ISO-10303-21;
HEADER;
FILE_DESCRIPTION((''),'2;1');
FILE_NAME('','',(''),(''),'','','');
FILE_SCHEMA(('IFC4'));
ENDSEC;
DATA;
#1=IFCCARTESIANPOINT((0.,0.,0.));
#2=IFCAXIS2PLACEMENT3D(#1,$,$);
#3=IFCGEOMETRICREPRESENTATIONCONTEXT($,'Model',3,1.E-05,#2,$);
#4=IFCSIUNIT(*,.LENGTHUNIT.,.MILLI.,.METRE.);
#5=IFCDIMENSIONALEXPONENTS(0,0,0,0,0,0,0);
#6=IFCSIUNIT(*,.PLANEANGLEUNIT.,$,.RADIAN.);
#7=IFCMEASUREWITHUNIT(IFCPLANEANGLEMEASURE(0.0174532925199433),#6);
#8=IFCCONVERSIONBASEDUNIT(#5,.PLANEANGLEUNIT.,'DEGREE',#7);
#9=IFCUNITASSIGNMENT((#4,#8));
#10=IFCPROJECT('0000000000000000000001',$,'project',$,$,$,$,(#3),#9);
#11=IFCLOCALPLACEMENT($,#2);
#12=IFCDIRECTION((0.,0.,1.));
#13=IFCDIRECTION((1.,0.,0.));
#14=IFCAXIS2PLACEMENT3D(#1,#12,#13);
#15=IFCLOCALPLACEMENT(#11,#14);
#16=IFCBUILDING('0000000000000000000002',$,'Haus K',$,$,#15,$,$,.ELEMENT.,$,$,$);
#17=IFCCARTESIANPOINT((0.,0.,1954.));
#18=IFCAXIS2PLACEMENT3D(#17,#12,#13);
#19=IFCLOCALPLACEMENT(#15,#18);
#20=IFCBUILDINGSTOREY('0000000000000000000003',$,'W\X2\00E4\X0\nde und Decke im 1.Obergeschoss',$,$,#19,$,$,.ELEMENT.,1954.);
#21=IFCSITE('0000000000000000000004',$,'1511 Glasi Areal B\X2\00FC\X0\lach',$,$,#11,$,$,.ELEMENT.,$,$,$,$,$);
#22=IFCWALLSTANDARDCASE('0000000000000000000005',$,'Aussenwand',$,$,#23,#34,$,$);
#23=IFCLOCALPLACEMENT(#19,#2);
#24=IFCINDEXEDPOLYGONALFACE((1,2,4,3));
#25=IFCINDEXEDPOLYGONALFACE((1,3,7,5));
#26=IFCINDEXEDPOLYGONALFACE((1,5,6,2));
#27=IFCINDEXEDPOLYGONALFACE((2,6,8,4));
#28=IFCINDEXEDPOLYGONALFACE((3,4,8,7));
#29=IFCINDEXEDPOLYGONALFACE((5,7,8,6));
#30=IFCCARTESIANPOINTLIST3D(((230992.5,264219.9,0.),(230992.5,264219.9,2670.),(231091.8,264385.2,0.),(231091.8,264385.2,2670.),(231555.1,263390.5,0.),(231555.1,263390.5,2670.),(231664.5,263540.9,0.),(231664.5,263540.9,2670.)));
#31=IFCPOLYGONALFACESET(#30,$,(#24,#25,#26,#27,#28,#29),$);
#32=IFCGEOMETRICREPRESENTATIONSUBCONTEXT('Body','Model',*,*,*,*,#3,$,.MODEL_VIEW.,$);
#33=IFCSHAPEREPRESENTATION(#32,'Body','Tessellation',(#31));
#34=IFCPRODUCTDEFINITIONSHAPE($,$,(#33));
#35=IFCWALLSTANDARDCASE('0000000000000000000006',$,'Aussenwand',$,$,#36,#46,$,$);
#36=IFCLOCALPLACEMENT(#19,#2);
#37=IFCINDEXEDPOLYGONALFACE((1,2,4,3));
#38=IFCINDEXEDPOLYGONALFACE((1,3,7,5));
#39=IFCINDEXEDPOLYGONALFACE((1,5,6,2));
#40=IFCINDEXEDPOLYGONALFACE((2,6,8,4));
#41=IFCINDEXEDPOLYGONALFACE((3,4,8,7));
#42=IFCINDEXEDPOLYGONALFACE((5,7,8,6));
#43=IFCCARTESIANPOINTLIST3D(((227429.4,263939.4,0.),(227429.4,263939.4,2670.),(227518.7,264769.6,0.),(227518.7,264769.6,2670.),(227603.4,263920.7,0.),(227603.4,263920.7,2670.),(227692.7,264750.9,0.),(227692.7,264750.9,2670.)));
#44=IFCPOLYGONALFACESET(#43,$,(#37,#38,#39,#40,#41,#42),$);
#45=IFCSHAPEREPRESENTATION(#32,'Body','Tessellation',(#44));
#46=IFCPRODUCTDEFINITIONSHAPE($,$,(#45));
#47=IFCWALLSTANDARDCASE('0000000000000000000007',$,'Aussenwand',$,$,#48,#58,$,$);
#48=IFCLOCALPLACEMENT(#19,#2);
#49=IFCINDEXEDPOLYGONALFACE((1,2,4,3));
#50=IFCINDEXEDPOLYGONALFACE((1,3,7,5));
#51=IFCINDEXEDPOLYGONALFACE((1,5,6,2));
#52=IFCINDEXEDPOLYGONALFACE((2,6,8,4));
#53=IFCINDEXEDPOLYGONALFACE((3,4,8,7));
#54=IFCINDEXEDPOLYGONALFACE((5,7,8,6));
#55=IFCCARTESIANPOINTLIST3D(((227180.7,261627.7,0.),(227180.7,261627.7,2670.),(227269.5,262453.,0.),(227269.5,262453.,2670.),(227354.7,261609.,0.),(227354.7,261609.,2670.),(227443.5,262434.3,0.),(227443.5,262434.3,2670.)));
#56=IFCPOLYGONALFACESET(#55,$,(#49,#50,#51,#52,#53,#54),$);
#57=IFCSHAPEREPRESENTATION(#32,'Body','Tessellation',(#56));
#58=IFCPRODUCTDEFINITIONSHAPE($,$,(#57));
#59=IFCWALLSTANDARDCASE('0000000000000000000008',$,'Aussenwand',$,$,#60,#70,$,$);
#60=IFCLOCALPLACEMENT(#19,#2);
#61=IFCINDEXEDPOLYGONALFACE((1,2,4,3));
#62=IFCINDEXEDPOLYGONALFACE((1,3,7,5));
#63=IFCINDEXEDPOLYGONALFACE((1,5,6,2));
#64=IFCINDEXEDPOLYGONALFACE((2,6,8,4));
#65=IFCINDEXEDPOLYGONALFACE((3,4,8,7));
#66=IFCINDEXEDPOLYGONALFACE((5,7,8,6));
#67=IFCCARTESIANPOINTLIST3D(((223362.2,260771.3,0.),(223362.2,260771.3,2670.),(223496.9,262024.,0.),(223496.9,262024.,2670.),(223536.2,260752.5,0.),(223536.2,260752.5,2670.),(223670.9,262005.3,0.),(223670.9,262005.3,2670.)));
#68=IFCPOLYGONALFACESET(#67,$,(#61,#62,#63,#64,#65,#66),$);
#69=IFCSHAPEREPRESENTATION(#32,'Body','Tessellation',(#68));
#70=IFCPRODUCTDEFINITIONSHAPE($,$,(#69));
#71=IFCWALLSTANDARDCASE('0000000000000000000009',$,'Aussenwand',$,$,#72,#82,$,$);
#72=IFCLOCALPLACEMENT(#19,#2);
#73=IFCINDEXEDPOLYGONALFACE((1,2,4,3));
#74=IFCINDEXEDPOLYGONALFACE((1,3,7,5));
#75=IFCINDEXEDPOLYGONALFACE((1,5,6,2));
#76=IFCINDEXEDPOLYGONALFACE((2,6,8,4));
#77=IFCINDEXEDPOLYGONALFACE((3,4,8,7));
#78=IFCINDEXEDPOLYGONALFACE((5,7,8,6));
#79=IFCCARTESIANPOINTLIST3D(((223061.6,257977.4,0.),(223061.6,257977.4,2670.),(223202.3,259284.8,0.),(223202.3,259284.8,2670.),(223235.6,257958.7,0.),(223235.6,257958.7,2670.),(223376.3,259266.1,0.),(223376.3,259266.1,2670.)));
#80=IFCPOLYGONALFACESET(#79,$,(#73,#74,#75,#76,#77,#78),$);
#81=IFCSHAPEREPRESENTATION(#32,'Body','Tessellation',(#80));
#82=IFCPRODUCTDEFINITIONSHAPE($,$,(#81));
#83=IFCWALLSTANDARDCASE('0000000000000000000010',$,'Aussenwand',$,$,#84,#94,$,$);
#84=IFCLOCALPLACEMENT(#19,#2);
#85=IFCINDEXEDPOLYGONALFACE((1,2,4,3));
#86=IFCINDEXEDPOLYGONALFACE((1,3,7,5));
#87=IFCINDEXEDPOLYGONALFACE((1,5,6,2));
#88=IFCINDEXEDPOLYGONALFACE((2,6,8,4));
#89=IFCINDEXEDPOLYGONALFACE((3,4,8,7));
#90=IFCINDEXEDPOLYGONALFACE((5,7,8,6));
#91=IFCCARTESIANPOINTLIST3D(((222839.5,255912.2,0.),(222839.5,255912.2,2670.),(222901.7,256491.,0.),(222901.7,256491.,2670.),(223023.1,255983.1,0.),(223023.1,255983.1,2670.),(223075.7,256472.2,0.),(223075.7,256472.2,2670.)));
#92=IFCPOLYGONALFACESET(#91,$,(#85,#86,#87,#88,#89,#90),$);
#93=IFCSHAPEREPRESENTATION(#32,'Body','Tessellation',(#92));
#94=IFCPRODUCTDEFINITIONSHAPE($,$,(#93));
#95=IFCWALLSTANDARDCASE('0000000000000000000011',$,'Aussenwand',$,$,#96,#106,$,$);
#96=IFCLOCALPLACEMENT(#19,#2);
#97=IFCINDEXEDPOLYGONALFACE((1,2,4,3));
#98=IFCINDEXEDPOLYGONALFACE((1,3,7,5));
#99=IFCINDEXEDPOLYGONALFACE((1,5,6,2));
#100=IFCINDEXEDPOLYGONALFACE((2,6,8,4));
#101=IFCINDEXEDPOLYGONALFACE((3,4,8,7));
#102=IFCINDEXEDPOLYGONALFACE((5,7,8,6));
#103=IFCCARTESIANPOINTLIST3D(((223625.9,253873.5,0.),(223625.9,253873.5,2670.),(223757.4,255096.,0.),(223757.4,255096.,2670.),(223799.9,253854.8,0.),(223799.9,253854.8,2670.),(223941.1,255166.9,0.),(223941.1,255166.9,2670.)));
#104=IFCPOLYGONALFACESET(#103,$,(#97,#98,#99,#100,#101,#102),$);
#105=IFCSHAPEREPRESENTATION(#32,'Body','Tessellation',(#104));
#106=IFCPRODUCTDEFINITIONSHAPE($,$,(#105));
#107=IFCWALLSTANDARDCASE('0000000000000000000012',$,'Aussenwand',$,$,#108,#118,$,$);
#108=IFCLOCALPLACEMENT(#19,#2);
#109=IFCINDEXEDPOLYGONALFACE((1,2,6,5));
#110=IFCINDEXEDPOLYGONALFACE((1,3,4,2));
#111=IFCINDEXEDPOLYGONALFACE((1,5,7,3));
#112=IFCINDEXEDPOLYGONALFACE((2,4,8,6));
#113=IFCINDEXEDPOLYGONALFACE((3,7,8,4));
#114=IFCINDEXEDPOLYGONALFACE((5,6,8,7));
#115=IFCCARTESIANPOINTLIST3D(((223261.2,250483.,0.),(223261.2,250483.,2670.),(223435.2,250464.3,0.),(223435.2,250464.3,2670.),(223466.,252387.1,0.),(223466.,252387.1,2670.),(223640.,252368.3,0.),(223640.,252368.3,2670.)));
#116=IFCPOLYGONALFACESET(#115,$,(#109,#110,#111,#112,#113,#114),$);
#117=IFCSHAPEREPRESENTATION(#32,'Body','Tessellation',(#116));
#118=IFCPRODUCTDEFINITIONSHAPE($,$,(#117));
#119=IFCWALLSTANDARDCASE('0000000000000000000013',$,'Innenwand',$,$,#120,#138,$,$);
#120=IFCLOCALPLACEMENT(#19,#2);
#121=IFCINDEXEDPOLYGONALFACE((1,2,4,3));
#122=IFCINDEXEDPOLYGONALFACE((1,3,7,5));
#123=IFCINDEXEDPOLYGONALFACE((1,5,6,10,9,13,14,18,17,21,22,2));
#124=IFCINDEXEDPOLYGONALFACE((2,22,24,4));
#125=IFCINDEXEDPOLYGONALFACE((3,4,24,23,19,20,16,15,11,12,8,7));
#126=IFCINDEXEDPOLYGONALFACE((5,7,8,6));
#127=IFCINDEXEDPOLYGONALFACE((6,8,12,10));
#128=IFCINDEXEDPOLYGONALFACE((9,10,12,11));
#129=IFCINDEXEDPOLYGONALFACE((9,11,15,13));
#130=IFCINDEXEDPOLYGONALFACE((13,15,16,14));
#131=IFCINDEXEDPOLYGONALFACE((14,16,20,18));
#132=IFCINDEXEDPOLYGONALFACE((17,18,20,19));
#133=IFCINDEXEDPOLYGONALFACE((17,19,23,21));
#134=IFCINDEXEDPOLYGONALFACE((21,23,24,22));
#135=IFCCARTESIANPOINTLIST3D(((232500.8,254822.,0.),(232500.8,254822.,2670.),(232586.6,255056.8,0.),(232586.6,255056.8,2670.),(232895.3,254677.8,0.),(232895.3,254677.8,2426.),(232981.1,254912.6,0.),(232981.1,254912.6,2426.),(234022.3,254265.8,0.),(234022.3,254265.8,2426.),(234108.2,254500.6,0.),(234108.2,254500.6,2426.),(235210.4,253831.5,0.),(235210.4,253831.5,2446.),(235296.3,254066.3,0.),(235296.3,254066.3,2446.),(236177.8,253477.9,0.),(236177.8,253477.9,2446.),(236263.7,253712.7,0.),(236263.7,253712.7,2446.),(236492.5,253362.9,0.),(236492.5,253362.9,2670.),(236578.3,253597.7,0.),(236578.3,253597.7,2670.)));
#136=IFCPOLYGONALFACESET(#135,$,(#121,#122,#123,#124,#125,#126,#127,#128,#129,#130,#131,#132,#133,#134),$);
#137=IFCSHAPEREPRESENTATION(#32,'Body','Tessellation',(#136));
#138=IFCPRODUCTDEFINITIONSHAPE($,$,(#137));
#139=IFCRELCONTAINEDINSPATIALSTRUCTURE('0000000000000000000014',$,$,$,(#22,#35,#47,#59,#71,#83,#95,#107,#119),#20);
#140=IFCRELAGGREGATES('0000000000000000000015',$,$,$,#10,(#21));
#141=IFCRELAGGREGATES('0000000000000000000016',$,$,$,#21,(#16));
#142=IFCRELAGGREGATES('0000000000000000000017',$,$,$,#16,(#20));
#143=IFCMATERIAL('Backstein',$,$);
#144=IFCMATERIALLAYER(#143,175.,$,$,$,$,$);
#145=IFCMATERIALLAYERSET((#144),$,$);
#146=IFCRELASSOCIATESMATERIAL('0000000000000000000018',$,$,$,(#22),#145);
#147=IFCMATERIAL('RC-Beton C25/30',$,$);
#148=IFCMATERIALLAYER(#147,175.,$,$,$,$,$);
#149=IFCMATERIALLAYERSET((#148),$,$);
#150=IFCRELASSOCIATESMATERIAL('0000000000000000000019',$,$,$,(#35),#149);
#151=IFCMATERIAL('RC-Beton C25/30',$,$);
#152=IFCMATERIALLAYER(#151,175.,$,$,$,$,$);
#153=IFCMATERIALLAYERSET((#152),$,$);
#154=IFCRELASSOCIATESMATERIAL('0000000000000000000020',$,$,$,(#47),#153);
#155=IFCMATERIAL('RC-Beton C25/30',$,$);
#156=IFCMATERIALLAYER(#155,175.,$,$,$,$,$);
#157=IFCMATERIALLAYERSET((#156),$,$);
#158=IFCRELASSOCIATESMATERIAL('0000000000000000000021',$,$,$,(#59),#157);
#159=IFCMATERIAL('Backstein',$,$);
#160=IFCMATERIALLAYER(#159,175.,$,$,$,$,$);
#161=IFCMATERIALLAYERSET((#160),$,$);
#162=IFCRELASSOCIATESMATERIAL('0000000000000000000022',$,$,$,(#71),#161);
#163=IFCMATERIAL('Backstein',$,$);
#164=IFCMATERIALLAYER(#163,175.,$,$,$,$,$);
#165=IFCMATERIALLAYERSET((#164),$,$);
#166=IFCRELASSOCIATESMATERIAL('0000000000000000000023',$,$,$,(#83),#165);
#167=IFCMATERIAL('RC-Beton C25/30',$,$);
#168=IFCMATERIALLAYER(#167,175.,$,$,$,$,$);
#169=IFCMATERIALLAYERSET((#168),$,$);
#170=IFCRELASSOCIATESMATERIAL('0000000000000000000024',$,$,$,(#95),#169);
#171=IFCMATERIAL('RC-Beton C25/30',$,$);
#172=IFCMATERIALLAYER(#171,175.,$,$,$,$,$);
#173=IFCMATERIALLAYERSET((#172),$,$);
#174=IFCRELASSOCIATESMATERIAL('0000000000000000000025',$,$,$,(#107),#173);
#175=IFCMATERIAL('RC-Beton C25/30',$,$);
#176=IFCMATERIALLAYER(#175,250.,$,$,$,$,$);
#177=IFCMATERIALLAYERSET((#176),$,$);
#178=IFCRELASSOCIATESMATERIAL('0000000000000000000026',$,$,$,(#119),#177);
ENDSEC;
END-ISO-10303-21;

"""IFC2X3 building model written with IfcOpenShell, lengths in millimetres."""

from ifc_helpers import new_model, entity, si_unit, converted_unit, frame, frame_2d, origin, origin_with_axes, place, context, subcontext, project, spatial, polyline, rectangle, outline, extrude, material, layer, layer_set, layer_usage, element, save


model = new_model("IFC2X3")

# Units and contexts
model_context = context("Model", 3, precision=1e-05, world=origin())
body_context = subcontext(model_context, "Body", "Model", "MODEL_VIEW")
ifc_project = project(units=[si_unit("LENGTHUNIT", "METRE", prefix="MILLI"), converted_unit("PLANEANGLEUNIT", "DEGREE", entity("IfcPlaneAngleMeasure", 0.0174532925199433), si_unit("PLANEANGLEUNIT", "RADIAN"), dimensions=[0, 0, 0, 0, 0, 0, 0])], contexts=[model_context])

# Site, building, storey
site_placement = place(None, origin())
site = spatial("IfcSite", under=ifc_project, at=site_placement, Name="1511 Glasi Areal Bülach", CompositionType="ELEMENT")
building_placement = place(site_placement, origin_with_axes())
building = spatial("IfcBuilding", under=site, at=building_placement, Name="Haus K", CompositionType="ELEMENT")
storey_placement = place(building_placement, frame((0.0, 0.0, 1954.0), z_axis=(0.0, 0.0, 1.0), x_axis=(1.0, 0.0, 0.0)))
storey = spatial("IfcBuildingStorey", under=building, at=storey_placement, Name="Wände und Decke im 1.Obergeschoss", CompositionType="ELEMENT", Elevation=1954.0)

# Walls
ifc_material_1 = material(Name="Backstein")
ifc_layer_1 = layer(ifc_material_1, 175.0)
ifc_layer_set_1 = layer_set([ifc_layer_1])
ifc_layer_usage_1 = layer_usage(ifc_layer_set_1, "AXIS2", "POSITIVE", 0.0)
wall_1_placement = place(storey_placement, frame((231664.5, 263540.9, 0.0), z_axis=(0.0, 0.0, 1.0), x_axis=(-0.561361, 0.827571, 0.0)))
element("IfcWallStandardCase", 1, at=wall_1_placement, inside=storey, material=ifc_layer_usage_1, Name="Aussenwand", context=body_context, shape_type="SweptSolid", body=[
    extrude(outline(polyline([(0.0, 0.0), (1020.3, 0.0), (939.2, 175.0), (-63.0, 175.0), (0.0, 0.0)])), origin_with_axes(), (0.0, 0.0, 1.0), 2670.0),
])
ifc_material_2 = material(Name="RC-Beton C25/30")
ifc_layer_2 = layer(ifc_material_2, 175.0)
ifc_layer_set_2 = layer_set([ifc_layer_2])
ifc_layer_usage_2 = layer_usage(ifc_layer_set_2, "AXIS2", "POSITIVE", 0.0)
wall_2_placement = place(storey_placement, frame((227518.7, 264769.6, 0.0), z_axis=(0.0, 0.0, 1.0), x_axis=(-0.106958, -0.994264, 0.0)))
element("IfcWallStandardCase", 2, at=wall_2_placement, inside=storey, material=ifc_layer_usage_2, Name="Aussenwand", context=body_context, shape_type="SweptSolid", body=[
    extrude(rectangle(XDim=835.0, YDim=175.0, at=frame_2d((417.5, 87.5), x_axis=(1.0, 0.0))), origin_with_axes(), (0.0, 0.0, 1.0), 2670.0),
])
ifc_material_3 = material(Name="RC-Beton C25/30")
ifc_layer_3 = layer(ifc_material_3, 175.0)
ifc_layer_set_3 = layer_set([ifc_layer_3])
ifc_layer_usage_3 = layer_usage(ifc_layer_set_3, "AXIS2", "POSITIVE", 0.0)
wall_3_placement = place(storey_placement, frame((227269.5, 262453.0, 0.0), z_axis=(0.0, 0.0, 1.0), x_axis=(-0.106958, -0.994264, 0.0)))
element("IfcWallStandardCase", 3, at=wall_3_placement, inside=storey, material=ifc_layer_usage_3, Name="Aussenwand", context=body_context, shape_type="SweptSolid", body=[
    extrude(rectangle(XDim=830.0, YDim=175.0, at=frame_2d((415.0, 87.5), x_axis=(1.0, 0.0))), origin_with_axes(), (0.0, 0.0, 1.0), 2670.0),
])
ifc_material_4 = material(Name="RC-Beton C25/30")
ifc_layer_4 = layer(ifc_material_4, 175.0)
ifc_layer_set_4 = layer_set([ifc_layer_4])
ifc_layer_usage_4 = layer_usage(ifc_layer_set_4, "AXIS2", "POSITIVE", 0.0)
wall_4_placement = place(storey_placement, frame((223496.9, 262024.0, 0.0), z_axis=(0.0, 0.0, 1.0), x_axis=(-0.106958, -0.994264, 0.0)))
element("IfcWallStandardCase", 4, at=wall_4_placement, inside=storey, material=ifc_layer_usage_4, Name="Aussenwand", context=body_context, shape_type="SweptSolid", body=[
    extrude(rectangle(XDim=1260.0, YDim=175.0, at=frame_2d((630.0, 87.5), x_axis=(1.0, 0.0))), origin_with_axes(), (0.0, 0.0, 1.0), 2670.0),
])
ifc_material_5 = material(Name="Backstein")
ifc_layer_5 = layer(ifc_material_5, 175.0)
ifc_layer_set_5 = layer_set([ifc_layer_5])
ifc_layer_usage_5 = layer_usage(ifc_layer_set_5, "AXIS2", "POSITIVE", 0.0)
wall_5_placement = place(storey_placement, frame((223202.3, 259284.8, 0.0), z_axis=(0.0, 0.0, 1.0), x_axis=(-0.106958, -0.994264, 0.0)))
element("IfcWallStandardCase", 5, at=wall_5_placement, inside=storey, material=ifc_layer_usage_5, Name="Aussenwand", context=body_context, shape_type="SweptSolid", body=[
    extrude(rectangle(XDim=1315.0, YDim=175.0, at=frame_2d((657.5, 87.5), x_axis=(1.0, 0.0))), origin_with_axes(), (0.0, 0.0, 1.0), 2670.0),
])
ifc_material_6 = material(Name="Backstein")
ifc_layer_6 = layer(ifc_material_6, 175.0)
ifc_layer_set_6 = layer_set([ifc_layer_6])
ifc_layer_usage_6 = layer_usage(ifc_layer_set_6, "AXIS2", "POSITIVE", 0.0)
wall_6_placement = place(storey_placement, frame((222901.7, 256491.0, 0.0), z_axis=(0.0, 0.0, 1.0), x_axis=(-0.106958, -0.994264, 0.0)))
element("IfcWallStandardCase", 6, at=wall_6_placement, inside=storey, material=ifc_layer_usage_6, Name="Aussenwand", context=body_context, shape_type="SweptSolid", body=[
    extrude(outline(polyline([(0.0, 0.0), (582.1, 0.0), (492.0, 175.0), (0.0, 175.0), (0.0, 0.0)])), origin_with_axes(), (0.0, 0.0, 1.0), 2670.0),
])
ifc_material_7 = material(Name="RC-Beton C25/30")
ifc_layer_7 = layer(ifc_material_7, 175.0)
ifc_layer_set_7 = layer_set([ifc_layer_7])
ifc_layer_usage_7 = layer_usage(ifc_layer_set_7, "AXIS2", "POSITIVE", 0.0)
wall_7_placement = place(storey_placement, frame((223757.4, 255096.0, 0.0), z_axis=(0.0, 0.0, 1.0), x_axis=(-0.106958, -0.994264, 0.0)))
element("IfcWallStandardCase", 7, at=wall_7_placement, inside=storey, material=ifc_layer_usage_7, Name="Aussenwand", context=body_context, shape_type="SweptSolid", body=[
    extrude(outline(polyline([(0.0, 0.0), (1229.6, 0.0), (1229.6, 175.0), (-90.1, 175.0), (0.0, 0.0)])), origin_with_axes(), (0.0, 0.0, 1.0), 2670.0),
])
ifc_material_8 = material(Name="RC-Beton C25/30")
ifc_layer_8 = layer(ifc_material_8, 175.0)
ifc_layer_set_8 = layer_set([ifc_layer_8])
ifc_layer_usage_8 = layer_usage(ifc_layer_set_8, "AXIS2", "POSITIVE", 0.0)
wall_8_placement = place(storey_placement, frame((223466.0, 252387.1, 0.0), z_axis=(0.0, 0.0, 1.0), x_axis=(-0.106958, -0.994264, 0.0)))
element("IfcWallStandardCase", 8, at=wall_8_placement, inside=storey, material=ifc_layer_usage_8, Name="Aussenwand", context=body_context, shape_type="SweptSolid", body=[
    extrude(rectangle(XDim=1915.0, YDim=175.0, at=frame_2d((957.5, 87.5), x_axis=(1.0, 0.0))), origin_with_axes(), (0.0, 0.0, 1.0), 2670.0),
])

# Wall, openings
ifc_material_9 = material(Name="RC-Beton C25/30")
ifc_layer_9 = layer(ifc_material_9, 250.0)
ifc_layer_set_9 = layer_set([ifc_layer_9])
ifc_layer_usage_9 = layer_usage(ifc_layer_set_9, "AXIS2", "POSITIVE", 0.0)
wall_9_placement = place(storey_placement, frame((232500.8, 254822.0, 0.0), z_axis=(0.0, 0.0, 1.0), x_axis=(0.939214, -0.343332, 0.0)))
wall_9 = element("IfcWallStandardCase", 9, at=wall_9_placement, inside=storey, material=ifc_layer_usage_9, Name="Innenwand", context=body_context, shape_type="SweptSolid", body=[
    extrude(rectangle(XDim=4250.0, YDim=250.0, at=frame_2d((2125.0, 125.0), x_axis=(1.0, 0.0))), origin_with_axes(), (0.0, 0.0, 1.0), 2670.0),
])
opening_1_placement = place(wall_9_placement, frame((2885.0, 0.0, 0.0), z_axis=(0.0, 1.0, 0.0), x_axis=(0.0, 0.0, 1.0)))
element("IfcOpeningElement", 10, at=opening_1_placement, cuts=wall_9, ObjectType="Opening", context=body_context, shape_type="SweptSolid", body=[
    extrude(rectangle(XDim=2446.0, YDim=1030.0, at=frame_2d((1223.0, 515.0), x_axis=(1.0, 0.0))), origin_with_axes(), (0.0, 0.0, 1.0), 250.0),
])
opening_2_placement = place(wall_9_placement, frame((420.0, 0.0, 0.0), z_axis=(0.0, 1.0, 0.0), x_axis=(0.0, 0.0, 1.0)))
element("IfcOpeningElement", 11, at=opening_2_placement, cuts=wall_9, ObjectType="Opening", context=body_context, shape_type="SweptSolid", body=[
    extrude(rectangle(XDim=2426.0, YDim=1200.0, at=frame_2d((1213.0, 600.0), x_axis=(1.0, 0.0))), origin_with_axes(), (0.0, 0.0, 1.0), 250.0),
])

save(model, "model.ifc")
